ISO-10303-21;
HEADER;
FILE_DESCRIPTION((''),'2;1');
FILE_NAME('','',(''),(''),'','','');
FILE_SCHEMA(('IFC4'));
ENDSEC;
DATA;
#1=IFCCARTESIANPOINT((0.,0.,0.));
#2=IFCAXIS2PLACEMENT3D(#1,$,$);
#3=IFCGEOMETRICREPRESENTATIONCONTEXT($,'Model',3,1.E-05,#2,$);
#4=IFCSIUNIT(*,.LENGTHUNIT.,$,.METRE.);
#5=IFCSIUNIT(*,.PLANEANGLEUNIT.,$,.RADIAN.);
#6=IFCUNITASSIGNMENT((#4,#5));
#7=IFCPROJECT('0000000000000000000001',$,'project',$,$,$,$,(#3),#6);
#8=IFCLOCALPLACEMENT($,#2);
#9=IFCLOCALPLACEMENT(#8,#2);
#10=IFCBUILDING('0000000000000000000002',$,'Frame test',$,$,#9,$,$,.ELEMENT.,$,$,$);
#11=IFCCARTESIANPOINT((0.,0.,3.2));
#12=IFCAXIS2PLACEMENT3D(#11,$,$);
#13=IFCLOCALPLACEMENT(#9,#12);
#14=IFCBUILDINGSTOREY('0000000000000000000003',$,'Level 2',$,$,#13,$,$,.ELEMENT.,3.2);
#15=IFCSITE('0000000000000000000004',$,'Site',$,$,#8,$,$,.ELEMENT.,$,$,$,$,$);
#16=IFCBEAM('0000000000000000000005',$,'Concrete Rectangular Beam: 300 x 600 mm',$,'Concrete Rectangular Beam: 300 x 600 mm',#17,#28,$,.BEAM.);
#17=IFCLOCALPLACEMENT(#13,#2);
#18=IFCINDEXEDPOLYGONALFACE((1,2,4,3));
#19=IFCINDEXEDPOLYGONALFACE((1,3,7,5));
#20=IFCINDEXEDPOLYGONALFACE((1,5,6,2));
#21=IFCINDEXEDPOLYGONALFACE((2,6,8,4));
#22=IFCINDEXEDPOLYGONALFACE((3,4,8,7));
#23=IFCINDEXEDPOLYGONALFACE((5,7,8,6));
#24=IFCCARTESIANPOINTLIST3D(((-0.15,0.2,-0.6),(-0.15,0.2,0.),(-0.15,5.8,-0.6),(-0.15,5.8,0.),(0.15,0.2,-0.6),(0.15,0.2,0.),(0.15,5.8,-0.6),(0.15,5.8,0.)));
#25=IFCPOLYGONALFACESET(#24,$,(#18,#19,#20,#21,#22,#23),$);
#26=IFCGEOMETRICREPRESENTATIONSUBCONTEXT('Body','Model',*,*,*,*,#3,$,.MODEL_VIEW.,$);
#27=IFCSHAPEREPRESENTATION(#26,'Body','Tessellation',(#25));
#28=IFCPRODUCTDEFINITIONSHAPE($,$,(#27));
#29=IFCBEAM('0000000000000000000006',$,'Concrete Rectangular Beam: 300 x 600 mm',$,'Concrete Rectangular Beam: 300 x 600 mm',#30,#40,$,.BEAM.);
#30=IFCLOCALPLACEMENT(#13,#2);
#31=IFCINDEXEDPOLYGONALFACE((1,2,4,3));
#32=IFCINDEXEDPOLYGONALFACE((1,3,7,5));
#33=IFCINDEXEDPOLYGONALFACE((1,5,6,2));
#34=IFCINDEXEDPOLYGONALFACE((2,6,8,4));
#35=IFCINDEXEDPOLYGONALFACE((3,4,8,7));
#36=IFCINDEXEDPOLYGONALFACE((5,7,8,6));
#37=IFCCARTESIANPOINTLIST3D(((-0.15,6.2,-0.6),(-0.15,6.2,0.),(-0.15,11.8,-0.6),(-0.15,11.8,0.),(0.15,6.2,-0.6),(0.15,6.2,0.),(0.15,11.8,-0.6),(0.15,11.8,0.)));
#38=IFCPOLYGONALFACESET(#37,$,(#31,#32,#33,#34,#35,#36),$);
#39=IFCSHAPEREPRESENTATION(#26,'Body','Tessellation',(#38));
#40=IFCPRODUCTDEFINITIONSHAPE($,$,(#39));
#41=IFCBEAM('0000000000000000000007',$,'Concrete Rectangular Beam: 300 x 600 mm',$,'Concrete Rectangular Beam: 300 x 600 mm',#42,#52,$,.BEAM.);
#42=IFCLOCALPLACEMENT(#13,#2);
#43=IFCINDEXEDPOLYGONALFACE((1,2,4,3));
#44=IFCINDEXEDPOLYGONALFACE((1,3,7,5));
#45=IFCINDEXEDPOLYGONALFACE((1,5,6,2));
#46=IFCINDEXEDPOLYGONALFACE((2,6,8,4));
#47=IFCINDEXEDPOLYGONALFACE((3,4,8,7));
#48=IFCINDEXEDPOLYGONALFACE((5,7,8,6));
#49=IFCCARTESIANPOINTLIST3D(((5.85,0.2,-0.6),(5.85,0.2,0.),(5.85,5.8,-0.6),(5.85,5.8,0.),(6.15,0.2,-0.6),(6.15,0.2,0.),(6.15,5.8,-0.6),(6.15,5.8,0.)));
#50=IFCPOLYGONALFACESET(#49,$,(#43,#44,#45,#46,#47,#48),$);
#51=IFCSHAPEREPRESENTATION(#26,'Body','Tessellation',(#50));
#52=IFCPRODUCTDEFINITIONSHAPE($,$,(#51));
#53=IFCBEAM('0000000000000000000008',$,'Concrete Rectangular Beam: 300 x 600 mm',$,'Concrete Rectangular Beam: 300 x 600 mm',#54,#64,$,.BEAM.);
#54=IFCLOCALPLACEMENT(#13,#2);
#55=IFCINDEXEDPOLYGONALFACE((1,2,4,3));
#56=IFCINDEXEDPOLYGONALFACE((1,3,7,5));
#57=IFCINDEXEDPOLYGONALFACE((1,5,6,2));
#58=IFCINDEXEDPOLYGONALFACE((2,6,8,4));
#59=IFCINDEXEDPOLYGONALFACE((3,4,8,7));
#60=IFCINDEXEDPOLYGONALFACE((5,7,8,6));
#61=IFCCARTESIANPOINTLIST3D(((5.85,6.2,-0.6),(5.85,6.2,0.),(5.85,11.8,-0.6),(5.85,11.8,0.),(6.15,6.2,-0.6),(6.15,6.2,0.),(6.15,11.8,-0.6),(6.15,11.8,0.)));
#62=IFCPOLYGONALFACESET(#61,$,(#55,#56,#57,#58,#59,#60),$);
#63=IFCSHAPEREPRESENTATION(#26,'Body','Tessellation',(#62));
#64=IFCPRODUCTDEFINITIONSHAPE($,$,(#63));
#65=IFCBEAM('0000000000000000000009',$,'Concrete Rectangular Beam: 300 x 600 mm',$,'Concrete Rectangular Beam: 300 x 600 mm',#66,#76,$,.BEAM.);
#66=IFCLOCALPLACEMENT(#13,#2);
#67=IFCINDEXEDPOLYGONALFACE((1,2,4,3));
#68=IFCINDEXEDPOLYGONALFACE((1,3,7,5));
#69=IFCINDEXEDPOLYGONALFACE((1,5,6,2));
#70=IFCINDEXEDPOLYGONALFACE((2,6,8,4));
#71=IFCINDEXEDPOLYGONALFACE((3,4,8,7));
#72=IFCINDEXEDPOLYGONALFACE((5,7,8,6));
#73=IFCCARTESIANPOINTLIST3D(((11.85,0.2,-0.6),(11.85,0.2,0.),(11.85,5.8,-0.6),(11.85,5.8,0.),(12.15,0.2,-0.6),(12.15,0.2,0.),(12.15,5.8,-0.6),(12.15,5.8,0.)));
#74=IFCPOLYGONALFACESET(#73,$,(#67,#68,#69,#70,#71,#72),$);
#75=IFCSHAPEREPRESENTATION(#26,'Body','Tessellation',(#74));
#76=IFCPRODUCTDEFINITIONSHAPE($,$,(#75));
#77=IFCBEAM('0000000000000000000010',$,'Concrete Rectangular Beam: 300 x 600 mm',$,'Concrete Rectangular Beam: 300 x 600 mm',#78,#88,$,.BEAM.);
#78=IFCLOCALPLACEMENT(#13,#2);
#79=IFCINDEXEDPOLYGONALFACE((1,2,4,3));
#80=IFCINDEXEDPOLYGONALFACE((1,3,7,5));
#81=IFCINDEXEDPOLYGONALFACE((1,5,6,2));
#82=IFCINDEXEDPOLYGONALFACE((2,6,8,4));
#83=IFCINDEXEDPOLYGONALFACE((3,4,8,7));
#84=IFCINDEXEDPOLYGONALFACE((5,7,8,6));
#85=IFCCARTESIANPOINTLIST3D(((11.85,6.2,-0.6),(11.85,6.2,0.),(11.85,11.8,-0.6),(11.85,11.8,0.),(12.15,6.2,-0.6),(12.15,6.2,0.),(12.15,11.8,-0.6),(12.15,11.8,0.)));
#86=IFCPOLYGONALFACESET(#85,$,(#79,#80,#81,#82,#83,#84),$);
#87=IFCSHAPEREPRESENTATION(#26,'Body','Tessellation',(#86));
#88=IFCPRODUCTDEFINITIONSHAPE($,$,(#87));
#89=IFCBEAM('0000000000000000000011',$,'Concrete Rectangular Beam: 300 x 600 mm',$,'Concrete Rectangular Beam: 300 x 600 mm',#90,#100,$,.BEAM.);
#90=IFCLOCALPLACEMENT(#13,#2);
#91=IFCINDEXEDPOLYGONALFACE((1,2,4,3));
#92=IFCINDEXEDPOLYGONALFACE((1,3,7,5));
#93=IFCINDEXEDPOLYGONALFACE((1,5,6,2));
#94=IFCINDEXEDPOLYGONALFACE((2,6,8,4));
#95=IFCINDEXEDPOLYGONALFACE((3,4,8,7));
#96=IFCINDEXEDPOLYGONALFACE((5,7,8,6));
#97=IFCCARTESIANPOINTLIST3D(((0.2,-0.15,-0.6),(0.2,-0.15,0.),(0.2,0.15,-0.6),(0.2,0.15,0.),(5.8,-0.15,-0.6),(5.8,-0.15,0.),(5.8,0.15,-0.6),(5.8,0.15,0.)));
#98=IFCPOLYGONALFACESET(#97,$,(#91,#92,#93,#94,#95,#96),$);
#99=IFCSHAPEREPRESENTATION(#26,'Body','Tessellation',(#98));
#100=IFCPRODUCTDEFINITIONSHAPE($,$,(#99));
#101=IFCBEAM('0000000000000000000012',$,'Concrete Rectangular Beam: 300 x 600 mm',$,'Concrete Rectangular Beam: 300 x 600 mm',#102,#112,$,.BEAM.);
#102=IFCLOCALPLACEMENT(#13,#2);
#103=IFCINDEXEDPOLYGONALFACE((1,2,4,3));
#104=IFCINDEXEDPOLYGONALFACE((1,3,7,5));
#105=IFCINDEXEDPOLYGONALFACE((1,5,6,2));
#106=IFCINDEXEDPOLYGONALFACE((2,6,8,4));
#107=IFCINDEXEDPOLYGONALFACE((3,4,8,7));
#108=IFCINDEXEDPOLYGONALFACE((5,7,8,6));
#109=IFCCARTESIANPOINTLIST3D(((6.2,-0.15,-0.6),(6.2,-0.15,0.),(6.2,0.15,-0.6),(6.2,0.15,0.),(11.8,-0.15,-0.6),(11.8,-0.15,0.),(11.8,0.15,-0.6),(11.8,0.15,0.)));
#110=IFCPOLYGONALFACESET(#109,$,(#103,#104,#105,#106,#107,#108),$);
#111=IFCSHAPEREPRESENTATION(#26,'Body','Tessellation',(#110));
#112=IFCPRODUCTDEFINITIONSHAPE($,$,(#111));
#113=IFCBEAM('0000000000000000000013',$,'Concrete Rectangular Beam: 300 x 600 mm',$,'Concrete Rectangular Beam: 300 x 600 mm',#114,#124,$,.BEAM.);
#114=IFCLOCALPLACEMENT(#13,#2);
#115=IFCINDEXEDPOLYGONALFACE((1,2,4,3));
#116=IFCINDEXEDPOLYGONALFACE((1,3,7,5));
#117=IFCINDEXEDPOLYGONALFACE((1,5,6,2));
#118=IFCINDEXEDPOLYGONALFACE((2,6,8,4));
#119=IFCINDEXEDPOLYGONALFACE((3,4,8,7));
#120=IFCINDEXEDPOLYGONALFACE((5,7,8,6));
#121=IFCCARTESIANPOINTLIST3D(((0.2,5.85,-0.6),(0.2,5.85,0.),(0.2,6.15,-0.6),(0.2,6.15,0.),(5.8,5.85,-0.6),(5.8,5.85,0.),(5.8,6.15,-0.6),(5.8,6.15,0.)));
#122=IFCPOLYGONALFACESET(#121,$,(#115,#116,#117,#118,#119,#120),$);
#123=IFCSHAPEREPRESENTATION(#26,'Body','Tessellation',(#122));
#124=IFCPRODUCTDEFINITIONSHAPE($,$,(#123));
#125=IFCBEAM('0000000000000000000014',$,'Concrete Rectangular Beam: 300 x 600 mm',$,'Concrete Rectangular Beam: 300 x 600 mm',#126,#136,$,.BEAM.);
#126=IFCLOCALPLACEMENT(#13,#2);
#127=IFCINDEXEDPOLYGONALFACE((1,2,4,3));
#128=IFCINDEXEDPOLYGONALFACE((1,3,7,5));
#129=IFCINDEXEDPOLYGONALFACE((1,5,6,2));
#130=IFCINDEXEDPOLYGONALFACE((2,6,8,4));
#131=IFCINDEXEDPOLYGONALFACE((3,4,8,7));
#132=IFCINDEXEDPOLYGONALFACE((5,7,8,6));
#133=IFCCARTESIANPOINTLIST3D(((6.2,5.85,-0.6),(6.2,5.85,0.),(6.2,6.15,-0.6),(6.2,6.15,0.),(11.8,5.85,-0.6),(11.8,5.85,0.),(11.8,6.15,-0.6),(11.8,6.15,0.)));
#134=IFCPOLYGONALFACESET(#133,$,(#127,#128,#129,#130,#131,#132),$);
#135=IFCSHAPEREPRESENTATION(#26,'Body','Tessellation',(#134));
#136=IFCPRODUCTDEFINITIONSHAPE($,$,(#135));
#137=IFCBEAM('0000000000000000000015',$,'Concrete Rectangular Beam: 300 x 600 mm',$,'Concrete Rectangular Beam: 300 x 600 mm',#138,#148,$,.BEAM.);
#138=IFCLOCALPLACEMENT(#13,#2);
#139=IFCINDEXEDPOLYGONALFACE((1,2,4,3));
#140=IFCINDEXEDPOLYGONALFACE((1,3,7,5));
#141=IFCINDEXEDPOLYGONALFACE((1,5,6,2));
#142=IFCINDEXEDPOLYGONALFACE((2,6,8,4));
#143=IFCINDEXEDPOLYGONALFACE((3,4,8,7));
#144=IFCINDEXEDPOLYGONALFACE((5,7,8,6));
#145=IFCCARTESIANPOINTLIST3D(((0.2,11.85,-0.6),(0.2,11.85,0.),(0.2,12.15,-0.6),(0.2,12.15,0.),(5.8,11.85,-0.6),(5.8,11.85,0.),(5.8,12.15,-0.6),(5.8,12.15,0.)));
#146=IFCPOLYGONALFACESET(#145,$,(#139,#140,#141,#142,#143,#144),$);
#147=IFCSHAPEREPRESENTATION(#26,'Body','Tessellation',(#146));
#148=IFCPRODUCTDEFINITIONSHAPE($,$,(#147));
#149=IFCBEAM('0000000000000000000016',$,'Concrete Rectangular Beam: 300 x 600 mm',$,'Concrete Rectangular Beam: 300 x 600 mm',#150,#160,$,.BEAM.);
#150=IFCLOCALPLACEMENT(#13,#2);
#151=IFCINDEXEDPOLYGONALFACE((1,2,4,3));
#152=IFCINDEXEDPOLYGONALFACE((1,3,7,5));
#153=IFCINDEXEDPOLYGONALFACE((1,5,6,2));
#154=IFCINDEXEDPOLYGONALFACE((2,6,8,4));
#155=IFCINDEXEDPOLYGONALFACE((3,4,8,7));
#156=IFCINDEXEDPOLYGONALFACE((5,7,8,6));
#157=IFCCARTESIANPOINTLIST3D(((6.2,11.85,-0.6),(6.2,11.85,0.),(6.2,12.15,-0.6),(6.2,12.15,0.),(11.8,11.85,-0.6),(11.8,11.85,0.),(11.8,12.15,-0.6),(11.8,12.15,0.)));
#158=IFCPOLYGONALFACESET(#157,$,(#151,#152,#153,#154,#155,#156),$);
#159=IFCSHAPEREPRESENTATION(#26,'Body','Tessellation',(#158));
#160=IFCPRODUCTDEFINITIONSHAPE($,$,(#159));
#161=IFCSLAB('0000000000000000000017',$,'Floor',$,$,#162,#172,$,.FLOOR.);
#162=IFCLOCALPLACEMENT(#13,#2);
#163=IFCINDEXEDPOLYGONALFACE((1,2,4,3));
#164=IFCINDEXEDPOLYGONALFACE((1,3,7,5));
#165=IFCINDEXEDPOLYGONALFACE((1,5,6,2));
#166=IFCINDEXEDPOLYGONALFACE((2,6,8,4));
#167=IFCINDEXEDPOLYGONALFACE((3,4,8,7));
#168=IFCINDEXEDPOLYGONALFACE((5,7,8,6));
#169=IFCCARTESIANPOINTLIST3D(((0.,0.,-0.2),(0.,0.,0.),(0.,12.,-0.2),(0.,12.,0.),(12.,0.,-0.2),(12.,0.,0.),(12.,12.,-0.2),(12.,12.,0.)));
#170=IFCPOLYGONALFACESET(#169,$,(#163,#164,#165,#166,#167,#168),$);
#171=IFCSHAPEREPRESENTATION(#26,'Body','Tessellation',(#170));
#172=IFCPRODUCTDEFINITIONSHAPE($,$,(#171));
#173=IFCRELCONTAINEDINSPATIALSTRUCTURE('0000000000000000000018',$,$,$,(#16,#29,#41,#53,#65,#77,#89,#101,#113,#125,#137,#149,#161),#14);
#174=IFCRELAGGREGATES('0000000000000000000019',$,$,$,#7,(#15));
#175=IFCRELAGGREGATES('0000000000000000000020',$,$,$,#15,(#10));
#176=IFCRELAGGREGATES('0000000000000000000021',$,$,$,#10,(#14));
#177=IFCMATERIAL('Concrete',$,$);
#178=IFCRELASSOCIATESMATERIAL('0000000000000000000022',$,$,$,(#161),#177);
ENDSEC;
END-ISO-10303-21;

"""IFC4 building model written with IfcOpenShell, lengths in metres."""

from ifc_helpers import new_model, si_unit, frame, origin, place, context, subcontext, project, spatial, polyline, outline, extrude, material, element, save


model = new_model("IFC4")

# Units and contexts
model_context = context("Model", 3, precision=1e-05, world=origin())
body_context = subcontext(model_context, "Body", "Model", "MODEL_VIEW")
ifc_project = project(units=[si_unit("LENGTHUNIT", "METRE"), si_unit("PLANEANGLEUNIT", "RADIAN")], contexts=[model_context])

# Site, building, storey
site_placement = place(None, origin())
site = spatial("IfcSite", under=ifc_project, at=site_placement, Name="Site", CompositionType="ELEMENT")
building_placement = place(site_placement, origin())
building = spatial("IfcBuilding", under=site, at=building_placement, Name="Frame test", CompositionType="ELEMENT")
storey_placement = place(building_placement, frame((0.0, 0.0, 3.2)))
storey = spatial("IfcBuildingStorey", under=building, at=storey_placement, Name="Level 2", CompositionType="ELEMENT", Elevation=3.2)

# Beams
for number, where, z_axis, x_axis, name in (
    (1, (0.0, 0.2, -0.3), (0.0, 1.0, 0.0), (-1.0, 0.0, 0.0), "Concrete Rectangular Beam: 300 x 600 mm"),
    (2, (0.0, 6.2, -0.3), (0.0, 1.0, 0.0), (-1.0, 0.0, 0.0), "Concrete Rectangular Beam: 300 x 600 mm"),
    (3, (6.0, 0.2, -0.3), (0.0, 1.0, 0.0), (-1.0, 0.0, 0.0), "Concrete Rectangular Beam: 300 x 600 mm"),
    (4, (6.0, 6.2, -0.3), (0.0, 1.0, 0.0), (-1.0, 0.0, 0.0), "Concrete Rectangular Beam: 300 x 600 mm"),
    (5, (12.0, 0.2, -0.3), (0.0, 1.0, 0.0), (-1.0, 0.0, 0.0), "Concrete Rectangular Beam: 300 x 600 mm"),
    (6, (12.0, 6.2, -0.3), (0.0, 1.0, 0.0), (-1.0, 0.0, 0.0), "Concrete Rectangular Beam: 300 x 600 mm"),
    (7, (0.2, 0.0, -0.3), (1.0, 0.0, 0.0), (0.0, 1.0, 0.0), "Concrete Rectangular Beam: 300 x 600 mm"),
    (8, (6.2, 0.0, -0.3), (1.0, 0.0, 0.0), (0.0, 1.0, 0.0), "Concrete Rectangular Beam: 300 x 600 mm"),
    (9, (0.2, 6.0, -0.3), (1.0, 0.0, 0.0), (0.0, 1.0, 0.0), "Concrete Rectangular Beam: 300 x 600 mm"),
    (10, (6.2, 6.0, -0.3), (1.0, 0.0, 0.0), (0.0, 1.0, 0.0), "Concrete Rectangular Beam: 300 x 600 mm"),
    (11, (0.2, 12.0, -0.3), (1.0, 0.0, 0.0), (0.0, 1.0, 0.0), "Concrete Rectangular Beam: 300 x 600 mm"),
    (12, (6.2, 12.0, -0.3), (1.0, 0.0, 0.0), (0.0, 1.0, 0.0), "Concrete Rectangular Beam: 300 x 600 mm"),
):
    element("IfcBeam", number, at=place(storey_placement, frame(where, z_axis=z_axis, x_axis=x_axis)), inside=storey, Name=name, ObjectType="Concrete Rectangular Beam: 300 x 600 mm", PredefinedType="BEAM", context=body_context, shape_type="SweptSolid", body=[
        extrude(outline(polyline([(-0.15, -0.3), (0.15, -0.3), (0.15, 0.3), (-0.15, 0.3), (-0.15, -0.3)])), origin(), (0.0, 0.0, 1.0), 5.6),
    ])

# Slab
ifc_material = material(Name="Concrete")
slab_placement = place(storey_placement, frame((0.0, 0.0, -0.2)))
element("IfcSlab", 13, at=slab_placement, inside=storey, material=ifc_material, Name="Floor", PredefinedType="FLOOR", context=body_context, shape_type="SweptSolid", body=[
    extrude(outline(polyline([(0.0, 0.0), (12.0, 0.0), (12.0, 12.0), (0.0, 12.0), (0.0, 0.0)])), origin(), (0.0, 0.0, 1.0), 0.2),
])

save(model, "model.ifc")
